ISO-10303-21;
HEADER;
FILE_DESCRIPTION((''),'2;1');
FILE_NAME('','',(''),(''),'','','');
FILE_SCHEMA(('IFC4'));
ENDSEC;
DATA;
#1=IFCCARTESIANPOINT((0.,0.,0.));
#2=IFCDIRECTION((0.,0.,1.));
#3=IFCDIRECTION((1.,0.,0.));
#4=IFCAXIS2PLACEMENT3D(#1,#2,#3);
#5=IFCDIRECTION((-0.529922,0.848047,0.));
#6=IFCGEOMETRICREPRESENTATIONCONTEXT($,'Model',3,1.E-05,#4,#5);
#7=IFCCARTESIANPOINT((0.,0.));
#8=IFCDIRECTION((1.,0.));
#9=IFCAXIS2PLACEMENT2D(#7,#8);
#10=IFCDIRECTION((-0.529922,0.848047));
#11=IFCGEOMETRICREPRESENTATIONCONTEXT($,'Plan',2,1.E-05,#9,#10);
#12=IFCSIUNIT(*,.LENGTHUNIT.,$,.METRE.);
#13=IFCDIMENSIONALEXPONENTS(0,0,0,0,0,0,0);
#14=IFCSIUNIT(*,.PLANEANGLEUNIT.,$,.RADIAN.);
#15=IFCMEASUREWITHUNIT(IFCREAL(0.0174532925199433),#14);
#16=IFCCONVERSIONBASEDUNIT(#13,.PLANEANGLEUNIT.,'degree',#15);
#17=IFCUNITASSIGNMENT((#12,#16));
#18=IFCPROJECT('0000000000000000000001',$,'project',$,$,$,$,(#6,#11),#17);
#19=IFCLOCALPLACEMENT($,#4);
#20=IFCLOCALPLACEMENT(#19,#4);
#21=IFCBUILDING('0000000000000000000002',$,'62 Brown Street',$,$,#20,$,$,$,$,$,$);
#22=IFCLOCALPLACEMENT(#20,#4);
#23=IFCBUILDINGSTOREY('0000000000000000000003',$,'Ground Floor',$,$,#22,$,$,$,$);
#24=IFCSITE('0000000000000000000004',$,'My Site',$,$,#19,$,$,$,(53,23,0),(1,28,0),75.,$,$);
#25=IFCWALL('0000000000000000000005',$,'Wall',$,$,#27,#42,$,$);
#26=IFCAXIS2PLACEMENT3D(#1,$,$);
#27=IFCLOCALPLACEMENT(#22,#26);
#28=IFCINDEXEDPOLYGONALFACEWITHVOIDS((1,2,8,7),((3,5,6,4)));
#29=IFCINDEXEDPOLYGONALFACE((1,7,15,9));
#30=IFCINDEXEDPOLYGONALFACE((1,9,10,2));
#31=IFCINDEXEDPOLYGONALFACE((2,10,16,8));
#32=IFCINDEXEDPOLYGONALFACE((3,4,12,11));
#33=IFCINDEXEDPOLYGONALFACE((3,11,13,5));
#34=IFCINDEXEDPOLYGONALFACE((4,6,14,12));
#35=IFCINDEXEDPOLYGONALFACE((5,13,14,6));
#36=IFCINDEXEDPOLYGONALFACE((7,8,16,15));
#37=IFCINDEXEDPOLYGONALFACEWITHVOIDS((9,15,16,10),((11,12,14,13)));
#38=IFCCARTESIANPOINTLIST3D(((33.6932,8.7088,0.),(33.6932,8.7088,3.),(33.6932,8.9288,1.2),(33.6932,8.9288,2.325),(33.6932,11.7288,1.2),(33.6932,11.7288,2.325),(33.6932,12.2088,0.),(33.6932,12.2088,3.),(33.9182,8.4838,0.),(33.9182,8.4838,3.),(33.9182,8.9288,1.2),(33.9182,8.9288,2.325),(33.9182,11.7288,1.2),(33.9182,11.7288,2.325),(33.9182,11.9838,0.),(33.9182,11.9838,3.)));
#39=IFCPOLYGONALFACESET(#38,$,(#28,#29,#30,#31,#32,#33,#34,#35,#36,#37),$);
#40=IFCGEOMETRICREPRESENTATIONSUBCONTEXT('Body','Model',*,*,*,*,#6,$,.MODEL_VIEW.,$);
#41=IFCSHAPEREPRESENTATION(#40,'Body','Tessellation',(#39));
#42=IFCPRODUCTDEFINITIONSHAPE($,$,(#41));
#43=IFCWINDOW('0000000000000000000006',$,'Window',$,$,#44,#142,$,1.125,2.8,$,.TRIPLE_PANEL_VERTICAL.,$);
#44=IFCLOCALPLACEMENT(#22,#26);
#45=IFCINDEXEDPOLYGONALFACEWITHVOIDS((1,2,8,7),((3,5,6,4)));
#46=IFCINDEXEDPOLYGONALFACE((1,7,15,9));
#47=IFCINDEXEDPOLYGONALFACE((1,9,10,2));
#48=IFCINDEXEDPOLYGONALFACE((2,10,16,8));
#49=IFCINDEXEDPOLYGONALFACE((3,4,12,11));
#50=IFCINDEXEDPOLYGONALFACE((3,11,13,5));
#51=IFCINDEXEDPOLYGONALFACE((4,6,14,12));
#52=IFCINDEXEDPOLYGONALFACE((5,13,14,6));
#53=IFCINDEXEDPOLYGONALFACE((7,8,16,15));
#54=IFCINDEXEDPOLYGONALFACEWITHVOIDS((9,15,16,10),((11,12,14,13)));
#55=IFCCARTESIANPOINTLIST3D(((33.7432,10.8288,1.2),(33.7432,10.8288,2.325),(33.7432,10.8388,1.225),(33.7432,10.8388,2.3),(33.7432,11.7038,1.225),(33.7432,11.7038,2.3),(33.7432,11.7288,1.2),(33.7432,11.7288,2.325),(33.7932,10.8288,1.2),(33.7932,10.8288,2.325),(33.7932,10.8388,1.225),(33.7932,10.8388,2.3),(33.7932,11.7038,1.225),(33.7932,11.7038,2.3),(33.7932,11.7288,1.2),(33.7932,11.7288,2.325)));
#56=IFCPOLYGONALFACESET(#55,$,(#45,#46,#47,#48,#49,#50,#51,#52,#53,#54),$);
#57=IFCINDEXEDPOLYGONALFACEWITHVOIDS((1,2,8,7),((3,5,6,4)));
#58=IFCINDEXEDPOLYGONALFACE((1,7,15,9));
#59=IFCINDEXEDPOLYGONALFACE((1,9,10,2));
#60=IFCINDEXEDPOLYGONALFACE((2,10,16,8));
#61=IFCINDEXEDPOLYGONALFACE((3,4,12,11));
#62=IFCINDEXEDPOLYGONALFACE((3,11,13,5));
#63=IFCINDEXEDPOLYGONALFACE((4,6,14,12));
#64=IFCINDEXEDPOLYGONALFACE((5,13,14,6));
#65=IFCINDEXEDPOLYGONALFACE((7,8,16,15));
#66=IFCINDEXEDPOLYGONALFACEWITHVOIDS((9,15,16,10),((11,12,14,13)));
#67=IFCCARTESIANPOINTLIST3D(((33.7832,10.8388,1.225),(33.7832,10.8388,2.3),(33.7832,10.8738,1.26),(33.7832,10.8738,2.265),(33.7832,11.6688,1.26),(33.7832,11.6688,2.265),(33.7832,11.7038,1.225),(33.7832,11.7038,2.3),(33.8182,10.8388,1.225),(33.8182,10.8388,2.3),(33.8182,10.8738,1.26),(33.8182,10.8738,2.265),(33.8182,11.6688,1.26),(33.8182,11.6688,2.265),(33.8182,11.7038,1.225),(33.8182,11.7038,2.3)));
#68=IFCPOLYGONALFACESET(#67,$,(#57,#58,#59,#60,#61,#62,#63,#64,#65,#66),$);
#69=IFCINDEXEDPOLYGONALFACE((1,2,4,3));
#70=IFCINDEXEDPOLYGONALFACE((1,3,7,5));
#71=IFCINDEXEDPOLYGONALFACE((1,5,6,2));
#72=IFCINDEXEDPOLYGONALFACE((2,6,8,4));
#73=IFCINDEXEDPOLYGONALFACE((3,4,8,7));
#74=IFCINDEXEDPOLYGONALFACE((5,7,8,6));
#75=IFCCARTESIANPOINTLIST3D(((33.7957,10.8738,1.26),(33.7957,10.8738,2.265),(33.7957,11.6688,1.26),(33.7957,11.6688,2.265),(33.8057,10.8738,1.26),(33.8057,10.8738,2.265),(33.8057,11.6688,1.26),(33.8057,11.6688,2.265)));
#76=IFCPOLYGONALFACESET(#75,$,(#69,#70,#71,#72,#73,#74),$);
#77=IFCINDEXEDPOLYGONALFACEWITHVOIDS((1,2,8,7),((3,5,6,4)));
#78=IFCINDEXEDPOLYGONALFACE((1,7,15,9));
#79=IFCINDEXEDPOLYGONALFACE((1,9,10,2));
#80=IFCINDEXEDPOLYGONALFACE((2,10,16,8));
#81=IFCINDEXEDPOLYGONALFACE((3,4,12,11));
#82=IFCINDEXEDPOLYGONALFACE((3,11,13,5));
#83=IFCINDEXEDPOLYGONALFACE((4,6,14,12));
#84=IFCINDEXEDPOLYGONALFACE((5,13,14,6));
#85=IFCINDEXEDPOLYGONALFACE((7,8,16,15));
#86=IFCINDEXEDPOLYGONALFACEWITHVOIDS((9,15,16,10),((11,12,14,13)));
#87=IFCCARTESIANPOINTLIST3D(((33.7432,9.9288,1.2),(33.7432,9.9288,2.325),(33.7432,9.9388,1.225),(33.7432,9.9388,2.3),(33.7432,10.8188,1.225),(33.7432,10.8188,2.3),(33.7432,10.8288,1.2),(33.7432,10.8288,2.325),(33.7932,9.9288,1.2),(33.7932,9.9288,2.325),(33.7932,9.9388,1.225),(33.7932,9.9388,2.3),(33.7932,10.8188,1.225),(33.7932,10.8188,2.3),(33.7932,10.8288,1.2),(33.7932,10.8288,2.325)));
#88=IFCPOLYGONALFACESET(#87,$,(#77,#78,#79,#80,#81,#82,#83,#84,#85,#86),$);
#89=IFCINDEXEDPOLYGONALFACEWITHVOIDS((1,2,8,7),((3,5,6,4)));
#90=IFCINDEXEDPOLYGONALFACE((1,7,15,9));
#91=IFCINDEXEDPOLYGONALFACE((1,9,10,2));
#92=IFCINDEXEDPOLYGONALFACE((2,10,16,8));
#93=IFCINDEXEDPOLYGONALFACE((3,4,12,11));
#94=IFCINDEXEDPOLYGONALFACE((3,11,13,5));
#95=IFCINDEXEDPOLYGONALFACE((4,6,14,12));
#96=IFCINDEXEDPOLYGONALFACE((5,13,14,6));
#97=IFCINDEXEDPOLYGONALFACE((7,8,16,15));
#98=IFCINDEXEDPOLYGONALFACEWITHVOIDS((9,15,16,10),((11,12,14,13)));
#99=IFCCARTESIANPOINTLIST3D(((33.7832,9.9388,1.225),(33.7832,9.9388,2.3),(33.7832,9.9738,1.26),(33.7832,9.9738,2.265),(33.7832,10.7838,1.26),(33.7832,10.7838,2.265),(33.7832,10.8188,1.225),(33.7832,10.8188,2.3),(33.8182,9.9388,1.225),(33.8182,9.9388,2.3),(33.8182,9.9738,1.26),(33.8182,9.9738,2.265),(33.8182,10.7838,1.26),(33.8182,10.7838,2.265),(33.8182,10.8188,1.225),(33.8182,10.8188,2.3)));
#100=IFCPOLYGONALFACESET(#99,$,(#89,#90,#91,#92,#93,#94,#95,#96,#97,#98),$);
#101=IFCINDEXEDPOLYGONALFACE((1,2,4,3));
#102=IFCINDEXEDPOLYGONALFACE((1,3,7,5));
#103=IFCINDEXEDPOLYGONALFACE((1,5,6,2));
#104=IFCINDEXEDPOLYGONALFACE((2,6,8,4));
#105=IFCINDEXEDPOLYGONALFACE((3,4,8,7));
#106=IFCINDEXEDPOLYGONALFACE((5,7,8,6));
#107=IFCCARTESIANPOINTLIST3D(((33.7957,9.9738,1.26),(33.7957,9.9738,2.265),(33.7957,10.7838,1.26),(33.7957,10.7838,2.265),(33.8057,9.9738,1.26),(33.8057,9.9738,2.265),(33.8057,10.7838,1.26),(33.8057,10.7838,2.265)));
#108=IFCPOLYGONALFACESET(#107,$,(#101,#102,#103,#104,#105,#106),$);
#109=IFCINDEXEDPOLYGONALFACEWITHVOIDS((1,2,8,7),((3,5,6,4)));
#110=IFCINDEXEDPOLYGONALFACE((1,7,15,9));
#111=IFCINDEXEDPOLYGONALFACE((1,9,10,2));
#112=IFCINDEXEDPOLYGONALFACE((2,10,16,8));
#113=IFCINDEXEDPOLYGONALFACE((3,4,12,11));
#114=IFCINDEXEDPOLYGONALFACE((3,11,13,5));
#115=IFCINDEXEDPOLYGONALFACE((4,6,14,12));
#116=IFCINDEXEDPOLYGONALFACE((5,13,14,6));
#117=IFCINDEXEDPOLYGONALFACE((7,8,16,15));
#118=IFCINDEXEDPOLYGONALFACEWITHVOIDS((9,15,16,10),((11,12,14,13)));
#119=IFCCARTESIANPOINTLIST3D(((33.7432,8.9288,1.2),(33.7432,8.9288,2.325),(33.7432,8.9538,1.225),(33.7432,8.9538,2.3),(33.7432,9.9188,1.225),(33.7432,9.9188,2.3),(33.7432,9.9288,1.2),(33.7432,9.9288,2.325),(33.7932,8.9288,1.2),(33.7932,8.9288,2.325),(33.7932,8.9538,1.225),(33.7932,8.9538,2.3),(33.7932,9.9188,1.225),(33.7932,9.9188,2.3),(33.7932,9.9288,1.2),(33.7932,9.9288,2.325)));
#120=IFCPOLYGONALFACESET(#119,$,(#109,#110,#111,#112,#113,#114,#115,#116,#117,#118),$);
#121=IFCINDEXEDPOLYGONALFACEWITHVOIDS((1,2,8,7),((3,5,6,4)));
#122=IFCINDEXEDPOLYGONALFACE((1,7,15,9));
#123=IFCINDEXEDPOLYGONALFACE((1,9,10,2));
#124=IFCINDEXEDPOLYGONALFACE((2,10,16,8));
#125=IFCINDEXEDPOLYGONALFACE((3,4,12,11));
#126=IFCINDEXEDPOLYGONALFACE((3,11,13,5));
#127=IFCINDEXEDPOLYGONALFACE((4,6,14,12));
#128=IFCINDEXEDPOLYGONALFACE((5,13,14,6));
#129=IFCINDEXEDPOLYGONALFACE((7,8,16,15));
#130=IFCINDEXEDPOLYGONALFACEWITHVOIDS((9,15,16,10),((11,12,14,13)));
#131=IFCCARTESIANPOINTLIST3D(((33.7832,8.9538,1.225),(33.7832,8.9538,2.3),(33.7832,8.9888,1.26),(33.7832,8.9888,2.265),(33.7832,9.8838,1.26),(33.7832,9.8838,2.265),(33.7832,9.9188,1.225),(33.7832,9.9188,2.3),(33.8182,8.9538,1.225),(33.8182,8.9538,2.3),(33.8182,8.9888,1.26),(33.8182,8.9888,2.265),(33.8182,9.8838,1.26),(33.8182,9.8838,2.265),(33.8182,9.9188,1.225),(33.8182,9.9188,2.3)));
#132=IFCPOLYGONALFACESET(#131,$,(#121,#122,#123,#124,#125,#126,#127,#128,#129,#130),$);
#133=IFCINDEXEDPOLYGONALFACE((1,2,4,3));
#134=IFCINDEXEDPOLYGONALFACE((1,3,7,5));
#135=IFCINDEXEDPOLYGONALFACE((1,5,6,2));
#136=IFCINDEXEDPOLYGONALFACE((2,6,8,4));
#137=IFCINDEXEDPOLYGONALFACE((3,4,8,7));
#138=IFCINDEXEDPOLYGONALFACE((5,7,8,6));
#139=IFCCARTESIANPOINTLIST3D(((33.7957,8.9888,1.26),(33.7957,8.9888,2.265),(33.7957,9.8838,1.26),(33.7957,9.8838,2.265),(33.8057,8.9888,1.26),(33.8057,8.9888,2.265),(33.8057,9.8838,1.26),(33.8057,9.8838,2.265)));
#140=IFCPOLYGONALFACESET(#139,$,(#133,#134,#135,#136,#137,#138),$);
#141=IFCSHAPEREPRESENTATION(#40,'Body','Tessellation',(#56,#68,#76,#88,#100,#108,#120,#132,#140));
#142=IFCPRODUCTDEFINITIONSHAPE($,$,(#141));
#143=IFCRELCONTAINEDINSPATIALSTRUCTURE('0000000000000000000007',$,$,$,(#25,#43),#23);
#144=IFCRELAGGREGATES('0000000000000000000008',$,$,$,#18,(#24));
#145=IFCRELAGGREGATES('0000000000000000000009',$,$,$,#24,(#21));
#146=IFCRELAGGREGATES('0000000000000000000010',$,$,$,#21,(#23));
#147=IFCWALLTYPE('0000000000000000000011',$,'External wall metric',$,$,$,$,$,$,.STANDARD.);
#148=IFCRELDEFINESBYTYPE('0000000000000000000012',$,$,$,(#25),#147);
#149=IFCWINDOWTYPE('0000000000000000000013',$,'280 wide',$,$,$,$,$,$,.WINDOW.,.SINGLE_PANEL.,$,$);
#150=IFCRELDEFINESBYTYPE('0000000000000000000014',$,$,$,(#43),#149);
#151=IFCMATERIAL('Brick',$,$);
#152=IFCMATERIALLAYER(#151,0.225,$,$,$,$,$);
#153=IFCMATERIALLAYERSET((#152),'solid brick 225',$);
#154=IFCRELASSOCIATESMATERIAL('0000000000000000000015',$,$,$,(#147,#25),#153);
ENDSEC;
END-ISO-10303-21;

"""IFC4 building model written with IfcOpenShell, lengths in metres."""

from ifc_helpers import new_model, entity, si_unit, converted_unit, direction, frame, origin_with_axes, origin_2d_with_axis, place, context, subcontext, project, spatial, line, indexed_curve, outline, extrude, clip, halfspace, shape, source, transform, mapped, material, layer, layer_set, layer_usage, type_object, type_shapes, element, fill, save


model = new_model("IFC4")

# Units and contexts
model_context = context("Model", 3, precision=1e-05, world=origin_with_axes(), true_north=direction((-0.529922, 0.848047, 0.0)))
plan_context = context("Plan", 2, precision=1e-05, world=origin_2d_with_axis(), true_north=direction((-0.529922, 0.848047)))
body_context_1 = subcontext(model_context, "Body", "Model", "MODEL_VIEW")
body_context_2 = subcontext(plan_context, "Body", "Plan", "PLAN_VIEW")
ifc_project = project(units=[si_unit("LENGTHUNIT", "METRE"), converted_unit("PLANEANGLEUNIT", "degree", entity("IfcReal", 0.0174532925199433), si_unit("PLANEANGLEUNIT", "RADIAN"), dimensions=[0, 0, 0, 0, 0, 0, 0])], contexts=[model_context, plan_context])

# Site, building, storey
site_placement = place(None, origin_with_axes())
site = spatial("IfcSite", under=ifc_project, at=site_placement, Name="My Site", RefLatitude=(53, 23, 0), RefLongitude=(1, 28, 0), RefElevation=75.0)
building_placement = place(site_placement, origin_with_axes())
building = spatial("IfcBuilding", under=site, at=building_placement, Name="62 Brown Street")
storey_placement = place(building_placement, origin_with_axes())
storey = spatial("IfcBuildingStorey", under=building, at=storey_placement, Name="Ground Floor")

# Wall, opening, window
ifc_material_1 = material(Name="Brick")
ifc_layer_1 = layer(ifc_material_1, 0.225)
ifc_layer_set_1 = layer_set([ifc_layer_1], Name="solid brick 225")
ifc_layer_usage_1 = layer_usage(ifc_layer_set_1, "AXIS2", "POSITIVE", 0.0)
wall_type_1 = type_object("IfcWallType", Name="External wall metric", PredefinedType="STANDARD", material=ifc_layer_set_1)
wall_1_placement = place(storey_placement, frame((33.6932, 12.2088, 0.0), z_axis=(0.0, 0.0, 1.0), x_axis=(0.0, -1.0, 0.0)))
wall_1 = element("IfcWall", 1, at=wall_1_placement, inside=storey, type_object=wall_type_1, material=ifc_layer_usage_1, Name="Wall", context=body_context_1, shape_type="Clipping", body=[
    clip(clip(extrude(outline(indexed_curve([(0.0, 0.0), (0.0, 0.225), (3.725, 0.225), (3.725, 0.0), (0.0, 0.0)], self_intersect=False)), origin_with_axes(), (0.0, 0.0, 1.0), 3.0), halfspace(frame((0.0, 0.0, 0.0), z_axis=(-0.674995, 0.675001, 0.0), x_axis=(0.225, 0.224998, 0.0)), False)), halfspace(frame((3.5, 0.0, 0.0), z_axis=(0.674995, -0.674999, 0.0), x_axis=(0.225, 0.224998, 0.0)), False)),
])
shared_shape_1 = source(origin_with_axes(), body_context_1, "Body", "SweptSolid", [
    extrude(outline(indexed_curve([(0.0, 0.0), (2.8, 0.0), (2.8, 1.125), (0.0, 1.125)], segments=[line(1, 2, 3, 4, 1)])), frame((0.0, -0.1, 0.0), z_axis=(0.0, -1.0, 0.0), x_axis=(1.0, 0.0, 0.0)), (0.0, 0.0, -1.0), 0.425),
])
opening_1_placement = place(wall_1_placement, frame((0.48, 0.0, 1.2), z_axis=(0.0, 0.0, 1.0), x_axis=(1.0, 0.0, 0.0)))
opening_1 = element("IfcOpeningElement", 2, at=opening_1_placement, cuts=wall_1, PredefinedType="OPENING", context=body_context_1, shape_type="MappedRepresentation", body=[
    mapped(shared_shape_1, transform((0.0, 0.0, 0.0), x_axis=(1.0, 0.0, 0.0), y_axis=(0.0, 1.0, 0.0), z_axis=(0.0, 0.0, 1.0), scale=1.0)),
])
window_type_1 = type_object("IfcWindowType", Name="280 wide", PartitioningType="SINGLE_PANEL", PredefinedType="WINDOW")
shared_shape_2 = source(origin_with_axes(), body_context_1, "Body", "SweptSolid", [
    extrude(outline(indexed_curve([(0.0, 0.0), (0.9, 0.0), (0.9, 1.125), (0.0, 1.125)], segments=[line(1, 2, 3, 4, 1)]), holes=[indexed_curve([(0.025, 0.025), (0.89, 0.025), (0.89, 1.1), (0.025, 1.1)], segments=[line(1, 2, 3, 4, 1)])]), frame((0.0, 0.05, 0.0), z_axis=(0.0, -1.0, 0.0), x_axis=(1.0, 0.0, 0.0)), (0.0, 0.0, -1.0), 0.05),
    extrude(outline(indexed_curve([(0.0, 0.0), (0.865, 0.0), (0.865, 1.075), (0.0, 1.075)], segments=[line(1, 2, 3, 4, 1)]), holes=[indexed_curve([(0.035, 0.035), (0.83, 0.035), (0.83, 1.04), (0.035, 1.04)], segments=[line(1, 2, 3, 4, 1)])]), frame((0.025, 0.09, 0.025), z_axis=(0.0, -1.0, 0.0), x_axis=(1.0, 0.0, 0.0)), (0.0, 0.0, -1.0), 0.035),
    extrude(outline(indexed_curve([(0.035, 0.035), (0.83, 0.035), (0.83, 1.04), (0.035, 1.04)], segments=[line(1, 2, 3, 4, 1)])), frame((0.025, 0.1025, 0.025), z_axis=(0.0, -1.0, 0.0), x_axis=(1.0, 0.0, 0.0)), (0.0, 0.0, -1.0), 0.01),
    extrude(outline(indexed_curve([(0.0, 0.0), (0.9, 0.0), (0.9, 1.125), (0.0, 1.125)], segments=[line(1, 2, 3, 4, 1)]), holes=[indexed_curve([(0.01, 0.025), (0.89, 0.025), (0.89, 1.1), (0.01, 1.1)], segments=[line(1, 2, 3, 4, 1)])]), frame((0.9, 0.05, 0.0), z_axis=(0.0, -1.0, 0.0), x_axis=(1.0, 0.0, 0.0)), (0.0, 0.0, -1.0), 0.05),
    extrude(outline(indexed_curve([(0.0, 0.0), (0.88, 0.0), (0.88, 1.075), (0.0, 1.075)], segments=[line(1, 2, 3, 4, 1)]), holes=[indexed_curve([(0.035, 0.035), (0.845, 0.035), (0.845, 1.04), (0.035, 1.04)], segments=[line(1, 2, 3, 4, 1)])]), frame((0.91, 0.09, 0.025), z_axis=(0.0, -1.0, 0.0), x_axis=(1.0, 0.0, 0.0)), (0.0, 0.0, -1.0), 0.035),
    extrude(outline(indexed_curve([(0.035, 0.035), (0.845, 0.035), (0.845, 1.04), (0.035, 1.04)], segments=[line(1, 2, 3, 4, 1)])), frame((0.91, 0.1025, 0.025), z_axis=(0.0, -1.0, 0.0), x_axis=(1.0, 0.0, 0.0)), (0.0, 0.0, -1.0), 0.01),
    extrude(outline(indexed_curve([(0.0, 0.0), (1.0, 0.0), (1.0, 1.125), (0.0, 1.125)], segments=[line(1, 2, 3, 4, 1)]), holes=[indexed_curve([(0.01, 0.025), (0.975, 0.025), (0.975, 1.1), (0.01, 1.1)], segments=[line(1, 2, 3, 4, 1)])]), frame((1.8, 0.05, 0.0), z_axis=(0.0, -1.0, 0.0), x_axis=(1.0, 0.0, 0.0)), (0.0, 0.0, -1.0), 0.05),
    extrude(outline(indexed_curve([(0.0, 0.0), (0.965, 0.0), (0.965, 1.075), (0.0, 1.075)], segments=[line(1, 2, 3, 4, 1)]), holes=[indexed_curve([(0.035, 0.035), (0.93, 0.035), (0.93, 1.04), (0.035, 1.04)], segments=[line(1, 2, 3, 4, 1)])]), frame((1.81, 0.09, 0.025), z_axis=(0.0, -1.0, 0.0), x_axis=(1.0, 0.0, 0.0)), (0.0, 0.0, -1.0), 0.035),
    extrude(outline(indexed_curve([(0.035, 0.035), (0.93, 0.035), (0.93, 1.04), (0.035, 1.04)], segments=[line(1, 2, 3, 4, 1)])), frame((1.81, 0.1025, 0.025), z_axis=(0.0, -1.0, 0.0), x_axis=(1.0, 0.0, 0.0)), (0.0, 0.0, -1.0), 0.01),
])
shared_shape_3 = source(origin_with_axes(), body_context_2, "Body", "Curve2D", [
    entity("IfcIndexedPolyCurve", entity("IfcCartesianPointList2D", [[0.025, 0.05], [0.89, 0.05]])),
    entity("IfcIndexedPolyCurve", entity("IfcCartesianPointList2D", [[0.0, 0.1], [0.025, 0.1], [0.025, 0.05], [0.0, 0.05]]), [entity("IfcLineIndex", [1, 2, 3, 4, 1])]),
    entity("IfcIndexedPolyCurve", entity("IfcCartesianPointList2D", [[0.9, 0.1], [0.89, 0.1], [0.89, 0.05], [0.9, 0.05]])),
    entity("IfcIndexedPolyCurve", entity("IfcCartesianPointList2D", [[0.025, 0.09], [0.06, 0.09], [0.06, 0.125], [0.025, 0.125]]), [entity("IfcLineIndex", [1, 2, 3, 4, 1])]),
    entity("IfcIndexedPolyCurve", entity("IfcCartesianPointList2D", [[0.89, 0.09], [0.855, 0.09], [0.855, 0.125], [0.89, 0.125]]), [entity("IfcLineIndex", [1, 2, 3, 4, 1])]),
    entity("IfcIndexedPolyCurve", entity("IfcCartesianPointList2D", [[0.06, 0.09], [0.855, 0.09]])),
    entity("IfcIndexedPolyCurve", entity("IfcCartesianPointList2D", [[0.06, 0.125], [0.855, 0.125]])),
    entity("IfcIndexedPolyCurve", entity("IfcCartesianPointList2D", [[0.06, 0.1075], [0.855, 0.1075]])),
    entity("IfcIndexedPolyCurve", entity("IfcCartesianPointList2D", [[0.91, 0.05], [1.79, 0.05]])),
    entity("IfcIndexedPolyCurve", entity("IfcCartesianPointList2D", [[0.9, 0.1], [0.91, 0.1], [0.91, 0.05], [0.9, 0.05]])),
    entity("IfcIndexedPolyCurve", entity("IfcCartesianPointList2D", [[1.8, 0.1], [1.79, 0.1], [1.79, 0.05], [1.8, 0.05]])),
    entity("IfcIndexedPolyCurve", entity("IfcCartesianPointList2D", [[0.91, 0.09], [0.945, 0.09], [0.945, 0.125], [0.91, 0.125]]), [entity("IfcLineIndex", [1, 2, 3, 4, 1])]),
    entity("IfcIndexedPolyCurve", entity("IfcCartesianPointList2D", [[1.79, 0.09], [1.755, 0.09], [1.755, 0.125], [1.79, 0.125]]), [entity("IfcLineIndex", [1, 2, 3, 4, 1])]),
    entity("IfcIndexedPolyCurve", entity("IfcCartesianPointList2D", [[0.945, 0.09], [1.755, 0.09]])),
    entity("IfcIndexedPolyCurve", entity("IfcCartesianPointList2D", [[0.945, 0.125], [1.755, 0.125]])),
    entity("IfcIndexedPolyCurve", entity("IfcCartesianPointList2D", [[0.945, 0.1075], [1.755, 0.1075]])),
    entity("IfcIndexedPolyCurve", entity("IfcCartesianPointList2D", [[1.81, 0.05], [2.775, 0.05]])),
    entity("IfcIndexedPolyCurve", entity("IfcCartesianPointList2D", [[1.8, 0.1], [1.81, 0.1], [1.81, 0.05], [1.8, 0.05]])),
    entity("IfcIndexedPolyCurve", entity("IfcCartesianPointList2D", [[2.8, 0.1], [2.775, 0.1], [2.775, 0.05], [2.8, 0.05]]), [entity("IfcLineIndex", [1, 2, 3, 4, 1])]),
    entity("IfcIndexedPolyCurve", entity("IfcCartesianPointList2D", [[1.81, 0.09], [1.845, 0.09], [1.845, 0.125], [1.81, 0.125]]), [entity("IfcLineIndex", [1, 2, 3, 4, 1])]),
    entity("IfcIndexedPolyCurve", entity("IfcCartesianPointList2D", [[2.775, 0.09], [2.74, 0.09], [2.74, 0.125], [2.775, 0.125]]), [entity("IfcLineIndex", [1, 2, 3, 4, 1])]),
    entity("IfcIndexedPolyCurve", entity("IfcCartesianPointList2D", [[1.845, 0.09], [2.74, 0.09]])),
    entity("IfcIndexedPolyCurve", entity("IfcCartesianPointList2D", [[1.845, 0.125], [2.74, 0.125]])),
    entity("IfcIndexedPolyCurve", entity("IfcCartesianPointList2D", [[1.845, 0.1075], [2.74, 0.1075]])),
])
type_shapes(window_type_1, [shared_shape_2, shared_shape_3])
window_1_placement = place(opening_1_placement, frame((0.0, 0.0, 0.0), z_axis=(0.0, 0.0, 1.0), x_axis=(1.0, 0.0, 0.0)))
window_1 = element("IfcWindow", 3, at=window_1_placement, inside=storey, type_object=window_type_1, Name="Window", OverallHeight=1.125, OverallWidth=2.8, PartitioningType="TRIPLE_PANEL_VERTICAL", shapes=[
    shape(body_context_1, "Body", "MappedRepresentation", [mapped(shared_shape_2, transform((0.0, 0.0, 0.0), x_axis=(1.0, 0.0, 0.0), y_axis=(0.0, 1.0, 0.0), z_axis=(0.0, 0.0, 1.0), scale=1.0))]),
    shape(body_context_2, "Body", "MappedRepresentation", [mapped(shared_shape_3, transform((0.0, 0.0, 0.0), x_axis=(1.0, 0.0, 0.0), y_axis=(0.0, 1.0, 0.0), z_axis=(0.0, 0.0, 1.0), scale=1.0))]),
])
fill(opening_1, window_1)

save(model, "model.ifc")
